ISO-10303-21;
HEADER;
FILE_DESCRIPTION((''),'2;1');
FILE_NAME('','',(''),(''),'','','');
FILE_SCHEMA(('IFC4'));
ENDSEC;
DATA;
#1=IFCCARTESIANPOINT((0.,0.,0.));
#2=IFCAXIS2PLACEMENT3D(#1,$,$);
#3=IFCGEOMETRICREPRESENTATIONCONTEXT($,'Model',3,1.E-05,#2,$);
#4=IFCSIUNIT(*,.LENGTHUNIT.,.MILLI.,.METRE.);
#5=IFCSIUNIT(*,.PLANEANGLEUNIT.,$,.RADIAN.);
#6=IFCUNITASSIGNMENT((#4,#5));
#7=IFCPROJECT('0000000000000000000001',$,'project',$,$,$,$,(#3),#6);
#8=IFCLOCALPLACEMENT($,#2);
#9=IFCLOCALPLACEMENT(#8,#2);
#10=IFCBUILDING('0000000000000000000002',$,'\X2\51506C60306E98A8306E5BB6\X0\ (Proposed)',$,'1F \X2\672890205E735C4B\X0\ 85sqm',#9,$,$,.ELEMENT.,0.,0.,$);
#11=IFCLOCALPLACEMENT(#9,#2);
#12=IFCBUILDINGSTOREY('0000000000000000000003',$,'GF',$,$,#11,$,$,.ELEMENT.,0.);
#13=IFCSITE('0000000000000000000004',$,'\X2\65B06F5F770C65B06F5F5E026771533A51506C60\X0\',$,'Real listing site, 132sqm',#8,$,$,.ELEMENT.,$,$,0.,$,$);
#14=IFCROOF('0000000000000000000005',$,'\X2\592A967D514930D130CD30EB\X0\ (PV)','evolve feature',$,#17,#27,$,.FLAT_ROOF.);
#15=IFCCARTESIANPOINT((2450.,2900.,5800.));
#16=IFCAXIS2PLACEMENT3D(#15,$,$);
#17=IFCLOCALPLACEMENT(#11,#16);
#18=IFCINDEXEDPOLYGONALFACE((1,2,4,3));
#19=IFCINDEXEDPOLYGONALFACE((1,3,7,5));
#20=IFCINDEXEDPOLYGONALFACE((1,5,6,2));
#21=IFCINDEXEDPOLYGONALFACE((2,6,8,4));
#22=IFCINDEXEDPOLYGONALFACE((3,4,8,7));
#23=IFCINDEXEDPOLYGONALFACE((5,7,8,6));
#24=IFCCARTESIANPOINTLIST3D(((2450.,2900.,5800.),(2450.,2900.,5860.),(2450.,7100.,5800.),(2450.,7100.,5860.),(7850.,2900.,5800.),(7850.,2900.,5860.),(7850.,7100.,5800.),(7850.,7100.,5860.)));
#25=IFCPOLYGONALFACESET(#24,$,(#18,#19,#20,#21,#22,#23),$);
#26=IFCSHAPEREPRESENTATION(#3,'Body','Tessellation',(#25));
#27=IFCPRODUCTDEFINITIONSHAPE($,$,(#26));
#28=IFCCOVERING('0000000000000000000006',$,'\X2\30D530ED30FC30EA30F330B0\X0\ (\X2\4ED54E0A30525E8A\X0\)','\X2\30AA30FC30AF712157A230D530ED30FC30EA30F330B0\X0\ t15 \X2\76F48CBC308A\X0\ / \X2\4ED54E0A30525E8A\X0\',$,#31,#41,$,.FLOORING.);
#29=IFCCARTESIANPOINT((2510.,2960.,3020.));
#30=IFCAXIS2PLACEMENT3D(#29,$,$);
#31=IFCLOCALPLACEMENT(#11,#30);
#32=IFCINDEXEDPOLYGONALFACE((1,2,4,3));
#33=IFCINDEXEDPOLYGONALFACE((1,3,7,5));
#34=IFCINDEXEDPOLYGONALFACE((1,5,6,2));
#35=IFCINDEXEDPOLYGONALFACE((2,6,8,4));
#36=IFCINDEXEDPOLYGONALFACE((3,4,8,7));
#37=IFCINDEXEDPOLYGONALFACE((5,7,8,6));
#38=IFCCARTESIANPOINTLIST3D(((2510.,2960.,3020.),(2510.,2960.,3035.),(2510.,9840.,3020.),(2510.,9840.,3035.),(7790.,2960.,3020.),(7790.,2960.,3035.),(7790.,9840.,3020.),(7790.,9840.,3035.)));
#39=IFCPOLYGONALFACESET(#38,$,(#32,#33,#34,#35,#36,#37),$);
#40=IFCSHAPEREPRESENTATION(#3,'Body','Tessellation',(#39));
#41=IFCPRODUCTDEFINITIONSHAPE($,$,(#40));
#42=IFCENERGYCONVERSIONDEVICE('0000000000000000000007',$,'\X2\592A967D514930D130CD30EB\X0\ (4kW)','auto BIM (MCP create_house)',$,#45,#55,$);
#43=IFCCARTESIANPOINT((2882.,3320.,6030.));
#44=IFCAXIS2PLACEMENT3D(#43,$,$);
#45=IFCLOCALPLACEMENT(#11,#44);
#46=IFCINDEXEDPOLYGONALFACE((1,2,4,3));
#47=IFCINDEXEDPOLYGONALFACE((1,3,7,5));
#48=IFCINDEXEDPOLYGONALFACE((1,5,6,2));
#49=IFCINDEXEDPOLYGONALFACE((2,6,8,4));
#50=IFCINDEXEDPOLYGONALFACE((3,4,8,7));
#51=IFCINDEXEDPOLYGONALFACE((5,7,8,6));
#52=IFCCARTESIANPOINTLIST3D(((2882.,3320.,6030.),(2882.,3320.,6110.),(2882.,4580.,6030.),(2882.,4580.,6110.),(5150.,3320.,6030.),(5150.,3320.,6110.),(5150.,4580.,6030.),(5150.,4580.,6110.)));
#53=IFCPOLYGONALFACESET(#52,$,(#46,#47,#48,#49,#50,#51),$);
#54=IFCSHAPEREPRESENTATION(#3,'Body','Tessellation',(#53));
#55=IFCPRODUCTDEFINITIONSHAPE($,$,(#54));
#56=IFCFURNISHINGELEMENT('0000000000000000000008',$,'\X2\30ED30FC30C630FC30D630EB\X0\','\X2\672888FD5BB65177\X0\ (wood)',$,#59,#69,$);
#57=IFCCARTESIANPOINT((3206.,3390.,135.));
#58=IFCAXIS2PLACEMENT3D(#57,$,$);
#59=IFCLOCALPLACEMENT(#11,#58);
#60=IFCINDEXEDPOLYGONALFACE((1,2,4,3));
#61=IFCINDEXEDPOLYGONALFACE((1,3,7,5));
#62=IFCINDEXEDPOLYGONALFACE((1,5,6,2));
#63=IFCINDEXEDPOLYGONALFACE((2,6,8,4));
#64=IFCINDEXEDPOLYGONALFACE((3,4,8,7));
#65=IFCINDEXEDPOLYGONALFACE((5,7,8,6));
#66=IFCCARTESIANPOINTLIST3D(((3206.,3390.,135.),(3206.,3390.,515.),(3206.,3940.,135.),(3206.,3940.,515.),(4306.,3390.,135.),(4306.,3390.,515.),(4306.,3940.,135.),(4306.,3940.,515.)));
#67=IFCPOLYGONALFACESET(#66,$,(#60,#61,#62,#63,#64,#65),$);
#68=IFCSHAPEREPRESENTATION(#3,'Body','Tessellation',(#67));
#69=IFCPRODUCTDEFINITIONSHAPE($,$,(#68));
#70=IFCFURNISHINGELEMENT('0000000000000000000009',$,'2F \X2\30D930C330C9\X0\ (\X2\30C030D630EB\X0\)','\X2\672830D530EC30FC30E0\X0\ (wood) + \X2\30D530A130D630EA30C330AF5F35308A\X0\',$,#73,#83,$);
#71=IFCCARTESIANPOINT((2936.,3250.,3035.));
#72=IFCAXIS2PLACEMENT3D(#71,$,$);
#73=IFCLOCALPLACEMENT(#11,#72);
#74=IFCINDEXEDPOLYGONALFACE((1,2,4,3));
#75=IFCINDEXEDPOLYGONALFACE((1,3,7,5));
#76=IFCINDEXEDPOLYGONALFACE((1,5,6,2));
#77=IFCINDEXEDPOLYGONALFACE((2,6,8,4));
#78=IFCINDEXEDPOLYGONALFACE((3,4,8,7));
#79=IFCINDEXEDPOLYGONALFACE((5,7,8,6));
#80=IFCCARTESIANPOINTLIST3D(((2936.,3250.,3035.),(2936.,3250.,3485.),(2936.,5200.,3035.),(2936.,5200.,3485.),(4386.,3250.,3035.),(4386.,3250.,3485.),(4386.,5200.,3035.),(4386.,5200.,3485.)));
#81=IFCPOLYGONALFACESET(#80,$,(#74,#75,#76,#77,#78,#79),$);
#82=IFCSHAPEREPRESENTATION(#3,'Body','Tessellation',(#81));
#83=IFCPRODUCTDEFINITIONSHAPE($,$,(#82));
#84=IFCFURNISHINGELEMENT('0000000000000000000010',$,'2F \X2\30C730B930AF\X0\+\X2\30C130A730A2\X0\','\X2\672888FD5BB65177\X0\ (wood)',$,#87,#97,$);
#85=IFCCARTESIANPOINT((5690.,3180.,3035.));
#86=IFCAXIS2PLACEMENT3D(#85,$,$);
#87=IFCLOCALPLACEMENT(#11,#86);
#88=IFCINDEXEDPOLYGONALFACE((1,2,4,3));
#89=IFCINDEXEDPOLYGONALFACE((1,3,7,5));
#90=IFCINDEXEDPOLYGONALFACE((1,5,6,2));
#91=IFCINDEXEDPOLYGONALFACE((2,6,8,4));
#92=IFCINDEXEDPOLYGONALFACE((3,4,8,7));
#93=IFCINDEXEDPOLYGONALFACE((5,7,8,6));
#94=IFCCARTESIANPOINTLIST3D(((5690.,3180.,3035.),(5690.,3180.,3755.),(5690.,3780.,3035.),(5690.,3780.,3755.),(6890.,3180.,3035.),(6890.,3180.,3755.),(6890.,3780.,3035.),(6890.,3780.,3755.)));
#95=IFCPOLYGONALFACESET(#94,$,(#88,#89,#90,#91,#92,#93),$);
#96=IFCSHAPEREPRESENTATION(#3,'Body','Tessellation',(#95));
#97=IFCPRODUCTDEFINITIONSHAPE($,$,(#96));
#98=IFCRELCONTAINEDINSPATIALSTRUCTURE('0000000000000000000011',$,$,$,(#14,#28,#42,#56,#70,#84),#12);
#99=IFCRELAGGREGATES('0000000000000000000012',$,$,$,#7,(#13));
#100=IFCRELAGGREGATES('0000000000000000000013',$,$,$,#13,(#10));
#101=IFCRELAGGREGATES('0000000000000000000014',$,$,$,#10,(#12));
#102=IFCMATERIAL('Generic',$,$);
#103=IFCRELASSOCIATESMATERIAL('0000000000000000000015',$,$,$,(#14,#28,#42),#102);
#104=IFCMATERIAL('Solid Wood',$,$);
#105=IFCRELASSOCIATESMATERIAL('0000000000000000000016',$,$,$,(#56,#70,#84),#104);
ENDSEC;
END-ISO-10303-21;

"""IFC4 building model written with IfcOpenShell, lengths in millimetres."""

from ifc_helpers import new_model, si_unit, frame, frame_2d, origin, place, context, project, spatial, rectangle, extrude, material, element, save


model = new_model("IFC4")

# Units and contexts
model_context = context("Model", 3, precision=1e-05, world=origin())
ifc_project = project(units=[si_unit("LENGTHUNIT", "METRE", prefix="MILLI"), si_unit("PLANEANGLEUNIT", "RADIAN")], contexts=[model_context])

# Site, building, storey
site_placement = place(None, origin())
site = spatial("IfcSite", under=ifc_project, at=site_placement, Name="新潟県新潟市東区児池", ObjectType="Real listing site, 132sqm", CompositionType="ELEMENT", RefElevation=0.0)
building_placement = place(site_placement, origin())
building = spatial("IfcBuilding", under=site, at=building_placement, Name="児池の風の家 (Proposed)", ObjectType="1F 木造平屋 85sqm", CompositionType="ELEMENT", ElevationOfRefHeight=0.0, ElevationOfTerrain=0.0)
storey_placement = place(building_placement, origin())
storey = spatial("IfcBuildingStorey", under=building, at=storey_placement, Name="GF", CompositionType="ELEMENT", Elevation=0.0)

# Shared definitions
ifc_material_1 = material(Name="Solid Wood")

# Shared definitions
ifc_material_2 = material(Name="Generic")

# Roof
roof_1_placement = place(storey_placement, frame((2450.0, 2900.0, 5800.0)))
element("IfcRoof", 1, at=roof_1_placement, inside=storey, material=ifc_material_2, Name="太陽光パネル (PV)", Description="evolve feature", PredefinedType="FLAT_ROOF", context=model_context, shape_type="SweptSolid", body=[
    extrude(rectangle(XDim=5400.0, YDim=4200.0, at=frame_2d((2700.0, 2100.0))), frame((2450.0, 2900.0, 5800.0)), (0.0, 0.0, 1.0), 60.0),
])

# Covering
covering_placement = place(storey_placement, frame((2510.0, 2960.0, 3020.0)))
element("IfcCovering", 2, at=covering_placement, inside=storey, material=ifc_material_2, Name="フローリング (仕上げ床)", Description="オーク無垢フローリング t15 直貼り / 仕上げ床", PredefinedType="FLOORING", context=model_context, shape_type="SweptSolid", body=[
    extrude(rectangle(XDim=5280.0, YDim=6880.0, at=frame_2d((2640.0, 3440.0))), frame((2510.0, 2960.0, 3020.0)), (0.0, 0.0, 1.0), 15.0),
])

# Energy conversion device
energy_conversion_device_placement = place(storey_placement, frame((2882.0, 3320.0, 6030.0)))
element("IfcEnergyConversionDevice", 3, at=energy_conversion_device_placement, inside=storey, material=ifc_material_2, Name="太陽光パネル (4kW)", Description="auto BIM (MCP create_house)", context=model_context, shape_type="SweptSolid", body=[
    extrude(rectangle(XDim=2268.0, YDim=1260.0, at=frame_2d((1134.0, 630.0))), frame((2882.0, 3320.0, 6030.0)), (0.0, 0.0, 1.0), 80.0),
])

# Furnishing elements
furnishing_1_placement = place(storey_placement, frame((3206.0, 3390.0, 135.0)))
element("IfcFurnishingElement", 4, at=furnishing_1_placement, inside=storey, material=ifc_material_1, Name="ローテーブル", Description="木製家具 (wood)", context=model_context, shape_type="SweptSolid", body=[
    extrude(rectangle(XDim=1100.0, YDim=550.0, at=frame_2d((550.0, 275.0))), frame((3206.0, 3390.0, 135.0)), (0.0, 0.0, 1.0), 380.0),
])
furnishing_2_placement = place(storey_placement, frame((2936.0, 3250.0, 3035.0)))
element("IfcFurnishingElement", 5, at=furnishing_2_placement, inside=storey, material=ifc_material_1, Name="2F ベッド (ダブル)", Description="木フレーム (wood) + ファブリック張り", context=model_context, shape_type="SweptSolid", body=[
    extrude(rectangle(XDim=1450.0, YDim=1950.0, at=frame_2d((725.0, 975.0))), frame((2936.0, 3250.0, 3035.0)), (0.0, 0.0, 1.0), 450.0),
])
furnishing_3_placement = place(storey_placement, frame((5690.0, 3180.0, 3035.0)))
element("IfcFurnishingElement", 6, at=furnishing_3_placement, inside=storey, material=ifc_material_1, Name="2F デスク+チェア", Description="木製家具 (wood)", context=model_context, shape_type="SweptSolid", body=[
    extrude(rectangle(XDim=1200.0, YDim=600.0, at=frame_2d((600.0, 300.0))), frame((5690.0, 3180.0, 3035.0)), (0.0, 0.0, 1.0), 720.0),
])

save(model, "model.ifc")
